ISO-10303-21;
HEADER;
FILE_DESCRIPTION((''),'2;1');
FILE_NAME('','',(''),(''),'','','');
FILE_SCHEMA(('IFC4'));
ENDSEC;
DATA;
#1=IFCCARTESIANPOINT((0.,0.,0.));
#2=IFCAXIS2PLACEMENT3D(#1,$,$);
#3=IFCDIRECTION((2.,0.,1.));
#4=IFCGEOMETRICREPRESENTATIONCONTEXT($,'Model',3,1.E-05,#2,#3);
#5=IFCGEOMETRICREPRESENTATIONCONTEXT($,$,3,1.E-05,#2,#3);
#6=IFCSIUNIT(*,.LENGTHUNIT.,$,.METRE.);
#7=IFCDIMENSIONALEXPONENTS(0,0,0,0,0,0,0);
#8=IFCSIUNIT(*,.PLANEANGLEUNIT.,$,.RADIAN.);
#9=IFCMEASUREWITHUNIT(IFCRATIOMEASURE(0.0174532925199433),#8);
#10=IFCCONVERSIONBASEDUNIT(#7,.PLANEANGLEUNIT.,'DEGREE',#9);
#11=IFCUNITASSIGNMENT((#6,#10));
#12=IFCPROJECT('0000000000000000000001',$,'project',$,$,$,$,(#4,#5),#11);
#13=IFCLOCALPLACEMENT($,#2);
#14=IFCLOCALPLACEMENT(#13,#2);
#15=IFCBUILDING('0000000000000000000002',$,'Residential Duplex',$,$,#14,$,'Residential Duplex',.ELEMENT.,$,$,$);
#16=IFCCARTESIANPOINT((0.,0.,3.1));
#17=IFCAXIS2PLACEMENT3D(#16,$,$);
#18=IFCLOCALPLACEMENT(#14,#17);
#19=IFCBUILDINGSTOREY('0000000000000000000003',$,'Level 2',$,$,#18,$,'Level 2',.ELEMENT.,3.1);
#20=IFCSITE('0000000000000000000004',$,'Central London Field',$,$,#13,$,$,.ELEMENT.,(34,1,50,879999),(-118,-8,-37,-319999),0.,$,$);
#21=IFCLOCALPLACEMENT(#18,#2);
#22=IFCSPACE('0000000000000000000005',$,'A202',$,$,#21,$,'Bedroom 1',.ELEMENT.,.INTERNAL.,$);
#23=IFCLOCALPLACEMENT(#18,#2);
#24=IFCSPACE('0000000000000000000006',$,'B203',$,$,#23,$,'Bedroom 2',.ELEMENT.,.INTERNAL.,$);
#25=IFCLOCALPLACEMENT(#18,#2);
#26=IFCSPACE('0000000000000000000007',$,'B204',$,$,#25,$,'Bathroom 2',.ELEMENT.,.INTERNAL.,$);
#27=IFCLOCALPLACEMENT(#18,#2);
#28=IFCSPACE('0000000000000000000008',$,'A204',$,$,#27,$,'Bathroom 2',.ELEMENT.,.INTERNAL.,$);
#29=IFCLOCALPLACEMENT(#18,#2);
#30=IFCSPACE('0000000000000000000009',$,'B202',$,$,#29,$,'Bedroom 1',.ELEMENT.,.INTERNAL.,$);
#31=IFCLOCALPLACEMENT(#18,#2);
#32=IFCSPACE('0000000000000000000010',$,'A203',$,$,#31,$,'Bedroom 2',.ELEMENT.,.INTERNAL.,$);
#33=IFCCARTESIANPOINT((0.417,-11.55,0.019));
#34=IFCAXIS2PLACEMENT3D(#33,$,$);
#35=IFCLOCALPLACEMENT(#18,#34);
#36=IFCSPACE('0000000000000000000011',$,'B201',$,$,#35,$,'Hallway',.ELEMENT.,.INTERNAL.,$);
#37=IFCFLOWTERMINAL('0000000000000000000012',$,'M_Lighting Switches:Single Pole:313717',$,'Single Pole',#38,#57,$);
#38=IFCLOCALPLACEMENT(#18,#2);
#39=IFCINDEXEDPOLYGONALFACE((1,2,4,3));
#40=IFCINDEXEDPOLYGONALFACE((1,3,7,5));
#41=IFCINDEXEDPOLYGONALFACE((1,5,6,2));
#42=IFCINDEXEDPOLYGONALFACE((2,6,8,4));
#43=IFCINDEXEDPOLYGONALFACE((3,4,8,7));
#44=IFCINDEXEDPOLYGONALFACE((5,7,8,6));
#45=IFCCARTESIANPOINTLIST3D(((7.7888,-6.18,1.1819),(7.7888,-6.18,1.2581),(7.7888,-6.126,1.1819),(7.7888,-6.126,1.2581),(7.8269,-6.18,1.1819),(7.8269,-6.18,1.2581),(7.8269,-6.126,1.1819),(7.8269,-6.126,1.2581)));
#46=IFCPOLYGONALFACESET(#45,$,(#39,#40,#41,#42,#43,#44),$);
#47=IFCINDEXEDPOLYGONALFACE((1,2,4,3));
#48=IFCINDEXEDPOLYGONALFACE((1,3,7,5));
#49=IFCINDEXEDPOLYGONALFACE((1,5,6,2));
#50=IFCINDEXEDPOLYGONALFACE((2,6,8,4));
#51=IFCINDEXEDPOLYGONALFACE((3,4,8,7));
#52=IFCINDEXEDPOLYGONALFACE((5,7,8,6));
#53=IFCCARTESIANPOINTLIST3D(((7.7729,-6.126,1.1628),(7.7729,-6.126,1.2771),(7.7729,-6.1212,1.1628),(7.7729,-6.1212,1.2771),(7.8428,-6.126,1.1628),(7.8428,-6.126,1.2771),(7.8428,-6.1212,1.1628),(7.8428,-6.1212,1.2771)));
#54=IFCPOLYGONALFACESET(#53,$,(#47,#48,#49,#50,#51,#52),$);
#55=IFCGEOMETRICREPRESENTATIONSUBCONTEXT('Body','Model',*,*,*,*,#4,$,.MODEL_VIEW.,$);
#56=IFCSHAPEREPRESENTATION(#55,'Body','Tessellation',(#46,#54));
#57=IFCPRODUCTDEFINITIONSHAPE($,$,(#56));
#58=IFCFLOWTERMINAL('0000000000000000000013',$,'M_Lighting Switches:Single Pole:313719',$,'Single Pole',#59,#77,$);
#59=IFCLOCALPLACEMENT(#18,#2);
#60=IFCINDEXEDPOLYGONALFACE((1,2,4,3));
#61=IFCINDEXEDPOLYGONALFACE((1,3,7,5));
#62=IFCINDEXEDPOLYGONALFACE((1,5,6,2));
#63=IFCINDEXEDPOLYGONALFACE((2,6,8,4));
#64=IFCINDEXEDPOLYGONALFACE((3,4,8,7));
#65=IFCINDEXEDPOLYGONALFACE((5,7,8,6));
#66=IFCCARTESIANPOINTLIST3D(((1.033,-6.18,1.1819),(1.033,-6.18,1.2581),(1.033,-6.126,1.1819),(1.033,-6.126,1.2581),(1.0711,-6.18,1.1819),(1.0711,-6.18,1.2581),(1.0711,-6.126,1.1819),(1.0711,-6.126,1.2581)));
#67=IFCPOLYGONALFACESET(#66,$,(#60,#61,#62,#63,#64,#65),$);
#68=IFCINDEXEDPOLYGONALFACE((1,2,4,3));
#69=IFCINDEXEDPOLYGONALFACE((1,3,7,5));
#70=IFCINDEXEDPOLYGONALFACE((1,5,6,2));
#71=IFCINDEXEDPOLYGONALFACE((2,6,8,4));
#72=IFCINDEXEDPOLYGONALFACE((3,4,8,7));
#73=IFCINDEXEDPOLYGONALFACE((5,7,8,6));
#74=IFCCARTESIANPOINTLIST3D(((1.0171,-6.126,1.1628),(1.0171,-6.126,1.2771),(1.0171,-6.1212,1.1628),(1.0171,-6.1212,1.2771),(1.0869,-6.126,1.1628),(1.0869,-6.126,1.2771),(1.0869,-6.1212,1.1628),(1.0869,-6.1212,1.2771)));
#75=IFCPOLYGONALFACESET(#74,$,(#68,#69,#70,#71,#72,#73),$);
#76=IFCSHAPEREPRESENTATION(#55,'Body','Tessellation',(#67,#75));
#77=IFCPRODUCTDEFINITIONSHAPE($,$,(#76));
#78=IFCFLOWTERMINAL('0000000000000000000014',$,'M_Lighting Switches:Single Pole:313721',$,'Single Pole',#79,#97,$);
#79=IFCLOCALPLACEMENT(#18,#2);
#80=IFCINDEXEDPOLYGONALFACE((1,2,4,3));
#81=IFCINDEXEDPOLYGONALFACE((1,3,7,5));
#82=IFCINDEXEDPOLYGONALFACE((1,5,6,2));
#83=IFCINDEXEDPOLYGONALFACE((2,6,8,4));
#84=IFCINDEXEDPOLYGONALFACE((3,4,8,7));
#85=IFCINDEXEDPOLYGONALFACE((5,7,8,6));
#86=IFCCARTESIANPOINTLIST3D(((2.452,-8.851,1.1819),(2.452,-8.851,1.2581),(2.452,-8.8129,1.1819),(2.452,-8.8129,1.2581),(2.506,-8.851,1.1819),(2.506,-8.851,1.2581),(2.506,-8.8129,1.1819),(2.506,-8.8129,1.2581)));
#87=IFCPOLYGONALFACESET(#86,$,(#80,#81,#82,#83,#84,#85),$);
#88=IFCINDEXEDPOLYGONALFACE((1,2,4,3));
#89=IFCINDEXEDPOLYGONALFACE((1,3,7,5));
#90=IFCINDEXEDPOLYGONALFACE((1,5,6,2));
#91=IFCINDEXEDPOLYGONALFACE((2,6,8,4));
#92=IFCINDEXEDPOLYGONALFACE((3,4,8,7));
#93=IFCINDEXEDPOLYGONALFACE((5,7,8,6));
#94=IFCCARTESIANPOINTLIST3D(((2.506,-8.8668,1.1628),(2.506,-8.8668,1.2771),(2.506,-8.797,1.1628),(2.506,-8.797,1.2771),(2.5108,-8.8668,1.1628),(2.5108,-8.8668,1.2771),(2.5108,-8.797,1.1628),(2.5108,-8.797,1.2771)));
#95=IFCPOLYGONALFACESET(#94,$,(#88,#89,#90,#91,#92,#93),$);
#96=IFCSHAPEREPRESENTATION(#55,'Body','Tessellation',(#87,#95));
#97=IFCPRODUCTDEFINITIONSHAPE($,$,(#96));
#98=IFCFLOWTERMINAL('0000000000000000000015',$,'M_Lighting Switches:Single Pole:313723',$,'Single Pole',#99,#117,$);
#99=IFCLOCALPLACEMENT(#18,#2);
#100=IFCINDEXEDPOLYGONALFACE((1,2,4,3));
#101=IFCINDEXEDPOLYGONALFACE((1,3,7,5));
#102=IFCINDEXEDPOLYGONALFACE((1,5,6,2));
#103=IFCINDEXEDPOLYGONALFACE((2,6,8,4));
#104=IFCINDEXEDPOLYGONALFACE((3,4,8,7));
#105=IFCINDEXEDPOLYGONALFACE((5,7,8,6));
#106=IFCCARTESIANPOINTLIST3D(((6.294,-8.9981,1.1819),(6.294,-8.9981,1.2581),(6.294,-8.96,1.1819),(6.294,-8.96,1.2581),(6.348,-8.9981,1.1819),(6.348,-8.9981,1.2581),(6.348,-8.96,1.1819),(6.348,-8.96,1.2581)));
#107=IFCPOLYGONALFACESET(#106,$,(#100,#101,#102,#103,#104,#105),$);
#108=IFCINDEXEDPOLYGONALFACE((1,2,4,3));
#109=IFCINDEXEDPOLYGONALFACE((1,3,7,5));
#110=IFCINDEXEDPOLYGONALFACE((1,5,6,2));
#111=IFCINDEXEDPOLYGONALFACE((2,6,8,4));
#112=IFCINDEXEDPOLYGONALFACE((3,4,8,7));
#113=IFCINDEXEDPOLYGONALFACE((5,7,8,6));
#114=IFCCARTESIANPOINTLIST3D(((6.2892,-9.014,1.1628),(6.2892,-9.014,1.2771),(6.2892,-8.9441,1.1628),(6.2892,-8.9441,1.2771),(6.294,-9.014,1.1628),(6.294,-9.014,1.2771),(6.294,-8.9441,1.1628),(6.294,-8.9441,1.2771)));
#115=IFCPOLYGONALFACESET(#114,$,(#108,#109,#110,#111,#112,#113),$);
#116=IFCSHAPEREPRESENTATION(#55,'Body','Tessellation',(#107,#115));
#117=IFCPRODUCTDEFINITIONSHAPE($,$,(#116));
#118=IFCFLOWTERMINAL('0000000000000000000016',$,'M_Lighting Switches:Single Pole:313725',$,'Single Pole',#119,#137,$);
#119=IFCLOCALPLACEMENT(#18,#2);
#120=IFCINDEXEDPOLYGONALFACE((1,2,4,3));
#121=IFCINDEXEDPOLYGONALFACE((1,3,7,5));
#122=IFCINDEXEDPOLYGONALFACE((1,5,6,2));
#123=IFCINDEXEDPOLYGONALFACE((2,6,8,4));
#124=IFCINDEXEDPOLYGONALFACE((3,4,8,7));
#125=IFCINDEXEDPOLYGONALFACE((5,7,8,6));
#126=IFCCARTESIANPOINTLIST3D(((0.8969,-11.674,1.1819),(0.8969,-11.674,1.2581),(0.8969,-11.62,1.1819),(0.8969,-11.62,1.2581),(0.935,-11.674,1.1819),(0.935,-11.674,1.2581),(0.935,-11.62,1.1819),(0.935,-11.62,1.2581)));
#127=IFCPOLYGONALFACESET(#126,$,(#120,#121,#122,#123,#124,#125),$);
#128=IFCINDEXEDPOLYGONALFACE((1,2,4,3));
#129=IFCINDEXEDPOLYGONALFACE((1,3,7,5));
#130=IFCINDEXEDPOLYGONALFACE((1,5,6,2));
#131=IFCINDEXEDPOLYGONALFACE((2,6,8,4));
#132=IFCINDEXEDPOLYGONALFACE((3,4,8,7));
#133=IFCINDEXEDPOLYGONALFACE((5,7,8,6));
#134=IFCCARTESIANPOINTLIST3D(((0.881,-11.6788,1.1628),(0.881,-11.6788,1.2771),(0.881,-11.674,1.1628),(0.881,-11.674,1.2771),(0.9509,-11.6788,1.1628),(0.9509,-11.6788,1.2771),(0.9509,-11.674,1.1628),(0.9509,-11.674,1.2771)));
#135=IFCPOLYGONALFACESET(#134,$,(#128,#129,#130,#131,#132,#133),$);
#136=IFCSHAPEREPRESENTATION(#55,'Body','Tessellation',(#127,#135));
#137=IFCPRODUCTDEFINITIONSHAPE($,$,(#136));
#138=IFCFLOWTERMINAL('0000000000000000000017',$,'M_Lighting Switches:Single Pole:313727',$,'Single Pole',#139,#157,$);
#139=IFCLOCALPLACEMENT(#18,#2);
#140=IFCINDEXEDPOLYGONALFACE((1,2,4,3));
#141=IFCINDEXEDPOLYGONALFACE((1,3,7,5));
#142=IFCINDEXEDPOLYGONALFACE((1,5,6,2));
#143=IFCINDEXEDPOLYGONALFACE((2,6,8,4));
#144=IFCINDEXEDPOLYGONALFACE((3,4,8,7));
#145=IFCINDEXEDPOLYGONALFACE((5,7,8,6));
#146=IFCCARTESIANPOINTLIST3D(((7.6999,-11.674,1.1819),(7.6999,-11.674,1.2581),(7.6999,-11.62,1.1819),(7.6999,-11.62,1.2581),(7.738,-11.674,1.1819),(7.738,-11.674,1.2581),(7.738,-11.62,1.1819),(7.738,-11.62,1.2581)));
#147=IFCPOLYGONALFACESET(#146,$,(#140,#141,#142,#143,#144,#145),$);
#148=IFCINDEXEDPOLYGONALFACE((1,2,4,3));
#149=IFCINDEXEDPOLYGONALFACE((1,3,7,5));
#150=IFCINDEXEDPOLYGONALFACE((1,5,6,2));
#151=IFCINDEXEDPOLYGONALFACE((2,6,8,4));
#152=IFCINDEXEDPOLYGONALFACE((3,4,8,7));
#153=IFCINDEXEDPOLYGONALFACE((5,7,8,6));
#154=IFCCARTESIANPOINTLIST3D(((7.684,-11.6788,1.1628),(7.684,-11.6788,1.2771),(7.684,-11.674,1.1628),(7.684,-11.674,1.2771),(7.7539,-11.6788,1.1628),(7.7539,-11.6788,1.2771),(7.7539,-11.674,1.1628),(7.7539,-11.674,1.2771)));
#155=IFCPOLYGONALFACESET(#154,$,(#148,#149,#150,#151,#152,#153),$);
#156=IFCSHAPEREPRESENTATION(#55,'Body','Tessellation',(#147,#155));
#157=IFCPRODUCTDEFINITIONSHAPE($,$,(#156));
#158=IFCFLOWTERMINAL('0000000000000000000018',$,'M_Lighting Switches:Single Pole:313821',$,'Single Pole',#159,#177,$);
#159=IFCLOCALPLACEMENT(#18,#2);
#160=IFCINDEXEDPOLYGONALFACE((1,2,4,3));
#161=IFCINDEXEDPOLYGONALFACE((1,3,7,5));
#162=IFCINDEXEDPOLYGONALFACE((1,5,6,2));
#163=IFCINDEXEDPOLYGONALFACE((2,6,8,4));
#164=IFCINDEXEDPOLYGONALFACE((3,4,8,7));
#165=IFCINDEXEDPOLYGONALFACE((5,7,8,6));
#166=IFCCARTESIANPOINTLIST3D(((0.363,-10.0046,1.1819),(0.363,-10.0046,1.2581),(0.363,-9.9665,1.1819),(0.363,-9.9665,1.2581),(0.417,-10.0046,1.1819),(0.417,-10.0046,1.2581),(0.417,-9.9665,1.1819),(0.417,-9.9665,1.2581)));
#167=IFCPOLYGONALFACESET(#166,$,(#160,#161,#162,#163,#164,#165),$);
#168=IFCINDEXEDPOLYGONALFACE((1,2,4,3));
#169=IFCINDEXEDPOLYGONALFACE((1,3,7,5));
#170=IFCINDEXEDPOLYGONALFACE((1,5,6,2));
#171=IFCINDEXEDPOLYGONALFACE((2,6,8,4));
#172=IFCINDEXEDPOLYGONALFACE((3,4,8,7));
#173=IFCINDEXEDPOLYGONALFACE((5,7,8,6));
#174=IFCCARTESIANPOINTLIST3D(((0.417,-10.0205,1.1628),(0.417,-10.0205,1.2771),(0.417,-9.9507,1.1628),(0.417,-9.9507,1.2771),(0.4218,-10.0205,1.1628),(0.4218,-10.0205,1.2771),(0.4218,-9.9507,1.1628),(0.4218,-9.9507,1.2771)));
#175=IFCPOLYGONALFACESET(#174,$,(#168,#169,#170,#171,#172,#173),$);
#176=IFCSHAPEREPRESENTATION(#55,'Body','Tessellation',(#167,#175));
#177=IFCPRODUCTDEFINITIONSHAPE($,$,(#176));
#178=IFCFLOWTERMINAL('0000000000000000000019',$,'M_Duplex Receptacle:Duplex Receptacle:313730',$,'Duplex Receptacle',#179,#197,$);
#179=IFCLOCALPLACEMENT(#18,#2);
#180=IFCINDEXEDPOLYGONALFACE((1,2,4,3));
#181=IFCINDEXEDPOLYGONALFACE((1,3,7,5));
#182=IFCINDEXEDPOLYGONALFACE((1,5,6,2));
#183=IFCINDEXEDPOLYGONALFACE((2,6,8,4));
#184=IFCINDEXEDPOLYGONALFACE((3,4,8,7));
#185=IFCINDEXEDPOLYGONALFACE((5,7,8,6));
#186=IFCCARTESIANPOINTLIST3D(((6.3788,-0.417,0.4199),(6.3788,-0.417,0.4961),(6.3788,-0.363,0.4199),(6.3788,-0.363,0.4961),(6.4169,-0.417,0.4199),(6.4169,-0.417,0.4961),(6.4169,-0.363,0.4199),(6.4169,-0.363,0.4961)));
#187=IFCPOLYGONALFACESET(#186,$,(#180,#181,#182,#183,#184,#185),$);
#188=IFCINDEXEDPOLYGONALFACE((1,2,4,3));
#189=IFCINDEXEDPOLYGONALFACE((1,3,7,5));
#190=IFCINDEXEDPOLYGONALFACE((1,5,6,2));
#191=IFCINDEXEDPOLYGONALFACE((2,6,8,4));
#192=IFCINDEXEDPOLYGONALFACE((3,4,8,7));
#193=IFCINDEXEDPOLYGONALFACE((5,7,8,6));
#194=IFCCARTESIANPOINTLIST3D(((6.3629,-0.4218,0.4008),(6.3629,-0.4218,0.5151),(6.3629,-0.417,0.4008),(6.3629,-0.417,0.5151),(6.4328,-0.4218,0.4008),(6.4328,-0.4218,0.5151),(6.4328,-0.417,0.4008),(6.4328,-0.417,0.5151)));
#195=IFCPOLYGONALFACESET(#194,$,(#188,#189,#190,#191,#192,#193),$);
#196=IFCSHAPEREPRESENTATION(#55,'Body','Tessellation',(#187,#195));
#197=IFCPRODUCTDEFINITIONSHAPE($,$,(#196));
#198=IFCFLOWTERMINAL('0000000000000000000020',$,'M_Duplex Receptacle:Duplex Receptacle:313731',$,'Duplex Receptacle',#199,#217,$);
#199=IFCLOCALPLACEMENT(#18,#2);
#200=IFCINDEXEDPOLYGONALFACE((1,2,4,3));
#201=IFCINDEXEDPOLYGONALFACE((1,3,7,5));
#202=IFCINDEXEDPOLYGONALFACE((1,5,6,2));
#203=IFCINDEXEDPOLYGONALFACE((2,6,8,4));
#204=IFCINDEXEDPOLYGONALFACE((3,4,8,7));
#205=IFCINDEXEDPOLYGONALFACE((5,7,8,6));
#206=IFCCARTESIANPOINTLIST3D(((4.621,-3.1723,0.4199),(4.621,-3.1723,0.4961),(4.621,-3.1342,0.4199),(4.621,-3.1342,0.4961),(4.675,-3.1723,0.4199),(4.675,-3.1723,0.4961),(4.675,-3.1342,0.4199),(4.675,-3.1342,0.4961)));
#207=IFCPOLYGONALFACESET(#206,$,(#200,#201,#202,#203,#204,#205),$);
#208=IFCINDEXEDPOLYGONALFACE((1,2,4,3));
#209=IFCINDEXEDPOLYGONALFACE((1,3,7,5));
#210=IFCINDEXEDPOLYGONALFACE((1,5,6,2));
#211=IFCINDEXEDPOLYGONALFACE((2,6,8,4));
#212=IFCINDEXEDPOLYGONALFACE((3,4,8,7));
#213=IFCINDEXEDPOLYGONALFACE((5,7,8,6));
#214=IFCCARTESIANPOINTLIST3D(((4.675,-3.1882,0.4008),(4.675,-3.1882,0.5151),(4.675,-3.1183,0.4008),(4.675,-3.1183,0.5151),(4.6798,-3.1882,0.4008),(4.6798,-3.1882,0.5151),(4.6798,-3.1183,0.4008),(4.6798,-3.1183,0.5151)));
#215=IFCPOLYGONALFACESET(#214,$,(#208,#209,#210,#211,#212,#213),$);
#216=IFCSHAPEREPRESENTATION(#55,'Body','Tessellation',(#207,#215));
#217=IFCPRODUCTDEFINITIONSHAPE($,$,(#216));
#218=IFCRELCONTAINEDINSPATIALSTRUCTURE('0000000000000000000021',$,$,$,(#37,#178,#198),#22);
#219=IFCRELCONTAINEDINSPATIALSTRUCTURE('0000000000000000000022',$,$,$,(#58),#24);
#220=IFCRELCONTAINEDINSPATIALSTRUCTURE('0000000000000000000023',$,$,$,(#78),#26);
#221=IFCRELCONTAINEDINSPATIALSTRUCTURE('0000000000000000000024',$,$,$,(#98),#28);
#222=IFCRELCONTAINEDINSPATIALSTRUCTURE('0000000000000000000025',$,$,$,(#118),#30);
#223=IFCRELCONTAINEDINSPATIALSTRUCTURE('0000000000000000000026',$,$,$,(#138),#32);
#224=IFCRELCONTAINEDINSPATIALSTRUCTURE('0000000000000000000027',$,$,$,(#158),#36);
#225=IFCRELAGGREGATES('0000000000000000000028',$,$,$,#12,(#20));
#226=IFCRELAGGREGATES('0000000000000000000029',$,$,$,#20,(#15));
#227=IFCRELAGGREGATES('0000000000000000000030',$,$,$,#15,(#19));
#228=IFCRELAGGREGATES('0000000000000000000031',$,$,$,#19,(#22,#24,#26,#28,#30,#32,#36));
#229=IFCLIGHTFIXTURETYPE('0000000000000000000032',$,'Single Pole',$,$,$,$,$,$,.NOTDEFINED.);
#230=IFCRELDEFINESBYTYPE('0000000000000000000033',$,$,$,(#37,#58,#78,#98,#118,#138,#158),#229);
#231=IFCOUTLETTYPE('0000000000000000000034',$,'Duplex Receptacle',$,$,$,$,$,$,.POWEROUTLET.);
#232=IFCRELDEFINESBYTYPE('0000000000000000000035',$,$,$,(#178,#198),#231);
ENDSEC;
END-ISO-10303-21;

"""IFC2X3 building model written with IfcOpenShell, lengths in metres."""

from ifc_helpers import new_model, entity, si_unit, converted_unit, direction, frame, frame_2d, origin, origin_2d_with_axis, place, context, subcontext, project, spatial, rectangle, extrude, source, transform, mapped, type_object, type_shapes, element, save


model = new_model("IFC2X3")

# Units and contexts
model_context = context("Model", 3, precision=1e-05, world=origin(), true_north=direction((2.0, 0.0, 1.0)))
context_of_model = context(None, 3, precision=1e-05, world=origin(), true_north=direction((2.0, 0.0, 1.0)))
body_context = subcontext(model_context, "Body", "Model", "MODEL_VIEW")
ifc_project = project(units=[si_unit("LENGTHUNIT", "METRE"), converted_unit("PLANEANGLEUNIT", "DEGREE", entity("IfcRatioMeasure", 0.0174532925199433), si_unit("PLANEANGLEUNIT", "RADIAN"), dimensions=[0, 0, 0, 0, 0, 0, 0])], contexts=[model_context, context_of_model])

# Site, building, storey, space
site_placement = place(None, origin())
site = spatial("IfcSite", under=ifc_project, at=site_placement, Name="Central London Field", CompositionType="ELEMENT", RefLatitude=(34, 1, 50, 879999), RefLongitude=(-118, -8, -37, -319999), RefElevation=0.0)
building_placement = place(site_placement, origin())
building = spatial("IfcBuilding", under=site, at=building_placement, Name="Residential Duplex", LongName="Residential Duplex", CompositionType="ELEMENT")
storey_placement = place(building_placement, frame((0.0, 0.0, 3.1)))
storey = spatial("IfcBuildingStorey", under=building, at=storey_placement, Name="Level 2", LongName="Level 2", CompositionType="ELEMENT", Elevation=3.1)
space_1_placement = place(storey_placement, origin())
space_1 = spatial("IfcSpace", under=storey, at=space_1_placement, Name="A202", LongName="Bedroom 1", CompositionType="ELEMENT", InteriorOrExteriorSpace="INTERNAL")

# Flow terminal
light_fixture_type = type_object("IfcLightFixtureType", Name="Single Pole", PredefinedType="NOTDEFINED")
shared_shape_1 = source(origin(), body_context, "Body", "SweptSolid", [
    extrude(rectangle(XDim=0.0381, YDim=0.0762, at=origin_2d_with_axis()), frame((0.0, 0.0, -0.054), z_axis=(0.0, 0.0, 1.0), x_axis=(-1.0, 0.0, 0.0)), (0.0, 0.0, 1.0), 0.054),
    extrude(rectangle(XDim=0.0698, YDim=0.1143, at=frame_2d((0.0, 0.0), x_axis=(1.0, 0.0))), frame((0.0, 0.0, 0.0), z_axis=(0.0, 0.0, 1.0), x_axis=(-1.0, 0.0, 0.0)), (0.0, 0.0, 1.0), 0.0048),
])
type_shapes(light_fixture_type, [shared_shape_1])
flow_terminal_1_placement = place(space_1_placement, frame((7.8079, -6.126, 1.22), z_axis=(0.0, 1.0, 0.0), x_axis=(-1.0, 0.0, 0.0)))
element("IfcFlowTerminal", 1, at=flow_terminal_1_placement, inside=space_1, type_object=light_fixture_type, Name="M_Lighting Switches:Single Pole:313717", ObjectType="Single Pole", context=body_context, shape_type="MappedRepresentation", body=[
    mapped(shared_shape_1, transform((0.0, 0.0, 0.0), scale=1.0)),
])

# Shared definitions
space_2_placement = place(storey_placement, origin())
space_2 = spatial("IfcSpace", under=storey, at=space_2_placement, Name="B203", LongName="Bedroom 2", CompositionType="ELEMENT", InteriorOrExteriorSpace="INTERNAL")

# Flow terminal
flow_terminal_2_placement = place(space_2_placement, frame((1.052, -6.126, 1.22), z_axis=(0.0, 1.0, 0.0), x_axis=(-1.0, 0.0, 0.0)))
element("IfcFlowTerminal", 2, at=flow_terminal_2_placement, inside=space_2, type_object=light_fixture_type, Name="M_Lighting Switches:Single Pole:313719", ObjectType="Single Pole", context=body_context, shape_type="MappedRepresentation", body=[
    mapped(shared_shape_1, transform((0.0, 0.0, 0.0), scale=1.0)),
])

# Shared definitions
space_3_placement = place(storey_placement, origin())
space_3 = spatial("IfcSpace", under=storey, at=space_3_placement, Name="B204", LongName="Bathroom 2", CompositionType="ELEMENT", InteriorOrExteriorSpace="INTERNAL")

# Flow terminal
flow_terminal_3_placement = place(space_3_placement, frame((2.506, -8.8319, 1.22), z_axis=(1.0, 0.0, 0.0), x_axis=(0.0, 1.0, 0.0)))
element("IfcFlowTerminal", 3, at=flow_terminal_3_placement, inside=space_3, type_object=light_fixture_type, Name="M_Lighting Switches:Single Pole:313721", ObjectType="Single Pole", context=body_context, shape_type="MappedRepresentation", body=[
    mapped(shared_shape_1, transform((0.0, 0.0, 0.0), scale=1.0)),
])

# Shared definitions
space_4_placement = place(storey_placement, origin())
space_4 = spatial("IfcSpace", under=storey, at=space_4_placement, Name="A204", LongName="Bathroom 2", CompositionType="ELEMENT", InteriorOrExteriorSpace="INTERNAL")

# Flow terminal
flow_terminal_4_placement = place(space_4_placement, frame((6.294, -8.9791, 1.22), z_axis=(-1.0, 0.0, 0.0), x_axis=(0.0, -1.0, 0.0)))
element("IfcFlowTerminal", 4, at=flow_terminal_4_placement, inside=space_4, type_object=light_fixture_type, Name="M_Lighting Switches:Single Pole:313723", ObjectType="Single Pole", context=body_context, shape_type="MappedRepresentation", body=[
    mapped(shared_shape_1, transform((0.0, 0.0, 0.0), scale=1.0)),
])

# Shared definitions
space_5_placement = place(storey_placement, origin())
space_5 = spatial("IfcSpace", under=storey, at=space_5_placement, Name="B202", LongName="Bedroom 1", CompositionType="ELEMENT", InteriorOrExteriorSpace="INTERNAL")

# Flow terminal
flow_terminal_5_placement = place(space_5_placement, frame((0.916, -11.674, 1.22), z_axis=(0.0, -1.0, 0.0), x_axis=(1.0, 0.0, 0.0)))
element("IfcFlowTerminal", 5, at=flow_terminal_5_placement, inside=space_5, type_object=light_fixture_type, Name="M_Lighting Switches:Single Pole:313725", ObjectType="Single Pole", context=body_context, shape_type="MappedRepresentation", body=[
    mapped(shared_shape_1, transform((0.0, 0.0, 0.0), scale=1.0)),
])

# Shared definitions
space_6_placement = place(storey_placement, origin())
space_6 = spatial("IfcSpace", under=storey, at=space_6_placement, Name="A203", LongName="Bedroom 2", CompositionType="ELEMENT", InteriorOrExteriorSpace="INTERNAL")

# Flow terminal
flow_terminal_6_placement = place(space_6_placement, frame((7.719, -11.674, 1.22), z_axis=(0.0, -1.0, 0.0), x_axis=(1.0, 0.0, 0.0)))
element("IfcFlowTerminal", 6, at=flow_terminal_6_placement, inside=space_6, type_object=light_fixture_type, Name="M_Lighting Switches:Single Pole:313727", ObjectType="Single Pole", context=body_context, shape_type="MappedRepresentation", body=[
    mapped(shared_shape_1, transform((0.0, 0.0, 0.0), scale=1.0)),
])

# Shared definitions
space_7_placement = place(storey_placement, frame((0.417, -11.55, 0.019)))
space_7 = spatial("IfcSpace", under=storey, at=space_7_placement, Name="B201", LongName="Hallway", CompositionType="ELEMENT", InteriorOrExteriorSpace="INTERNAL")

# Flow terminals
flow_terminal_7_placement = place(space_7_placement, frame((0.0, 1.5644, 1.201), z_axis=(1.0, 0.0, 0.0), x_axis=(0.0, 1.0, 0.0)))
element("IfcFlowTerminal", 7, at=flow_terminal_7_placement, inside=space_7, type_object=light_fixture_type, Name="M_Lighting Switches:Single Pole:313821", ObjectType="Single Pole", context=body_context, shape_type="MappedRepresentation", body=[
    mapped(shared_shape_1, transform((0.0, 0.0, 0.0), scale=1.0)),
])
outlet_type = type_object("IfcOutletType", Name="Duplex Receptacle", PredefinedType="POWEROUTLET")
shared_shape_2 = source(origin(), body_context, "Body", "SweptSolid", [
    extrude(rectangle(XDim=0.0381, YDim=0.0762, at=origin_2d_with_axis()), frame((0.0, 0.0, -0.054), z_axis=(0.0, 0.0, 1.0), x_axis=(-1.0, 0.0, 0.0)), (0.0, 0.0, 1.0), 0.054),
    extrude(rectangle(XDim=0.0698, YDim=0.1143, at=frame_2d((0.0, 0.0), x_axis=(1.0, 0.0))), frame((0.0, 0.0, 0.0), z_axis=(0.0, 0.0, 1.0), x_axis=(-1.0, 0.0, 0.0)), (0.0, 0.0, 1.0), 0.0048),
])
type_shapes(outlet_type, [shared_shape_2])
for number, where, z_axis, x_axis, name in (
    (8, (6.3979, -0.417, 0.458), (0.0, -1.0, 0.0), (1.0, 0.0, 0.0), "M_Duplex Receptacle:Duplex Receptacle:313730"),
    (9, (4.675, -3.1533, 0.458), (1.0, 0.0, 0.0), (0.0, 1.0, 0.0), "M_Duplex Receptacle:Duplex Receptacle:313731"),
):
    element("IfcFlowTerminal", number, at=place(space_1_placement, frame(where, z_axis=z_axis, x_axis=x_axis)), inside=space_1, type_object=outlet_type, Name=name, ObjectType="Duplex Receptacle", context=body_context, shape_type="MappedRepresentation", body=[
        mapped(shared_shape_2, transform((0.0, 0.0, 0.0), scale=1.0)),
    ])

save(model, "model.ifc")
